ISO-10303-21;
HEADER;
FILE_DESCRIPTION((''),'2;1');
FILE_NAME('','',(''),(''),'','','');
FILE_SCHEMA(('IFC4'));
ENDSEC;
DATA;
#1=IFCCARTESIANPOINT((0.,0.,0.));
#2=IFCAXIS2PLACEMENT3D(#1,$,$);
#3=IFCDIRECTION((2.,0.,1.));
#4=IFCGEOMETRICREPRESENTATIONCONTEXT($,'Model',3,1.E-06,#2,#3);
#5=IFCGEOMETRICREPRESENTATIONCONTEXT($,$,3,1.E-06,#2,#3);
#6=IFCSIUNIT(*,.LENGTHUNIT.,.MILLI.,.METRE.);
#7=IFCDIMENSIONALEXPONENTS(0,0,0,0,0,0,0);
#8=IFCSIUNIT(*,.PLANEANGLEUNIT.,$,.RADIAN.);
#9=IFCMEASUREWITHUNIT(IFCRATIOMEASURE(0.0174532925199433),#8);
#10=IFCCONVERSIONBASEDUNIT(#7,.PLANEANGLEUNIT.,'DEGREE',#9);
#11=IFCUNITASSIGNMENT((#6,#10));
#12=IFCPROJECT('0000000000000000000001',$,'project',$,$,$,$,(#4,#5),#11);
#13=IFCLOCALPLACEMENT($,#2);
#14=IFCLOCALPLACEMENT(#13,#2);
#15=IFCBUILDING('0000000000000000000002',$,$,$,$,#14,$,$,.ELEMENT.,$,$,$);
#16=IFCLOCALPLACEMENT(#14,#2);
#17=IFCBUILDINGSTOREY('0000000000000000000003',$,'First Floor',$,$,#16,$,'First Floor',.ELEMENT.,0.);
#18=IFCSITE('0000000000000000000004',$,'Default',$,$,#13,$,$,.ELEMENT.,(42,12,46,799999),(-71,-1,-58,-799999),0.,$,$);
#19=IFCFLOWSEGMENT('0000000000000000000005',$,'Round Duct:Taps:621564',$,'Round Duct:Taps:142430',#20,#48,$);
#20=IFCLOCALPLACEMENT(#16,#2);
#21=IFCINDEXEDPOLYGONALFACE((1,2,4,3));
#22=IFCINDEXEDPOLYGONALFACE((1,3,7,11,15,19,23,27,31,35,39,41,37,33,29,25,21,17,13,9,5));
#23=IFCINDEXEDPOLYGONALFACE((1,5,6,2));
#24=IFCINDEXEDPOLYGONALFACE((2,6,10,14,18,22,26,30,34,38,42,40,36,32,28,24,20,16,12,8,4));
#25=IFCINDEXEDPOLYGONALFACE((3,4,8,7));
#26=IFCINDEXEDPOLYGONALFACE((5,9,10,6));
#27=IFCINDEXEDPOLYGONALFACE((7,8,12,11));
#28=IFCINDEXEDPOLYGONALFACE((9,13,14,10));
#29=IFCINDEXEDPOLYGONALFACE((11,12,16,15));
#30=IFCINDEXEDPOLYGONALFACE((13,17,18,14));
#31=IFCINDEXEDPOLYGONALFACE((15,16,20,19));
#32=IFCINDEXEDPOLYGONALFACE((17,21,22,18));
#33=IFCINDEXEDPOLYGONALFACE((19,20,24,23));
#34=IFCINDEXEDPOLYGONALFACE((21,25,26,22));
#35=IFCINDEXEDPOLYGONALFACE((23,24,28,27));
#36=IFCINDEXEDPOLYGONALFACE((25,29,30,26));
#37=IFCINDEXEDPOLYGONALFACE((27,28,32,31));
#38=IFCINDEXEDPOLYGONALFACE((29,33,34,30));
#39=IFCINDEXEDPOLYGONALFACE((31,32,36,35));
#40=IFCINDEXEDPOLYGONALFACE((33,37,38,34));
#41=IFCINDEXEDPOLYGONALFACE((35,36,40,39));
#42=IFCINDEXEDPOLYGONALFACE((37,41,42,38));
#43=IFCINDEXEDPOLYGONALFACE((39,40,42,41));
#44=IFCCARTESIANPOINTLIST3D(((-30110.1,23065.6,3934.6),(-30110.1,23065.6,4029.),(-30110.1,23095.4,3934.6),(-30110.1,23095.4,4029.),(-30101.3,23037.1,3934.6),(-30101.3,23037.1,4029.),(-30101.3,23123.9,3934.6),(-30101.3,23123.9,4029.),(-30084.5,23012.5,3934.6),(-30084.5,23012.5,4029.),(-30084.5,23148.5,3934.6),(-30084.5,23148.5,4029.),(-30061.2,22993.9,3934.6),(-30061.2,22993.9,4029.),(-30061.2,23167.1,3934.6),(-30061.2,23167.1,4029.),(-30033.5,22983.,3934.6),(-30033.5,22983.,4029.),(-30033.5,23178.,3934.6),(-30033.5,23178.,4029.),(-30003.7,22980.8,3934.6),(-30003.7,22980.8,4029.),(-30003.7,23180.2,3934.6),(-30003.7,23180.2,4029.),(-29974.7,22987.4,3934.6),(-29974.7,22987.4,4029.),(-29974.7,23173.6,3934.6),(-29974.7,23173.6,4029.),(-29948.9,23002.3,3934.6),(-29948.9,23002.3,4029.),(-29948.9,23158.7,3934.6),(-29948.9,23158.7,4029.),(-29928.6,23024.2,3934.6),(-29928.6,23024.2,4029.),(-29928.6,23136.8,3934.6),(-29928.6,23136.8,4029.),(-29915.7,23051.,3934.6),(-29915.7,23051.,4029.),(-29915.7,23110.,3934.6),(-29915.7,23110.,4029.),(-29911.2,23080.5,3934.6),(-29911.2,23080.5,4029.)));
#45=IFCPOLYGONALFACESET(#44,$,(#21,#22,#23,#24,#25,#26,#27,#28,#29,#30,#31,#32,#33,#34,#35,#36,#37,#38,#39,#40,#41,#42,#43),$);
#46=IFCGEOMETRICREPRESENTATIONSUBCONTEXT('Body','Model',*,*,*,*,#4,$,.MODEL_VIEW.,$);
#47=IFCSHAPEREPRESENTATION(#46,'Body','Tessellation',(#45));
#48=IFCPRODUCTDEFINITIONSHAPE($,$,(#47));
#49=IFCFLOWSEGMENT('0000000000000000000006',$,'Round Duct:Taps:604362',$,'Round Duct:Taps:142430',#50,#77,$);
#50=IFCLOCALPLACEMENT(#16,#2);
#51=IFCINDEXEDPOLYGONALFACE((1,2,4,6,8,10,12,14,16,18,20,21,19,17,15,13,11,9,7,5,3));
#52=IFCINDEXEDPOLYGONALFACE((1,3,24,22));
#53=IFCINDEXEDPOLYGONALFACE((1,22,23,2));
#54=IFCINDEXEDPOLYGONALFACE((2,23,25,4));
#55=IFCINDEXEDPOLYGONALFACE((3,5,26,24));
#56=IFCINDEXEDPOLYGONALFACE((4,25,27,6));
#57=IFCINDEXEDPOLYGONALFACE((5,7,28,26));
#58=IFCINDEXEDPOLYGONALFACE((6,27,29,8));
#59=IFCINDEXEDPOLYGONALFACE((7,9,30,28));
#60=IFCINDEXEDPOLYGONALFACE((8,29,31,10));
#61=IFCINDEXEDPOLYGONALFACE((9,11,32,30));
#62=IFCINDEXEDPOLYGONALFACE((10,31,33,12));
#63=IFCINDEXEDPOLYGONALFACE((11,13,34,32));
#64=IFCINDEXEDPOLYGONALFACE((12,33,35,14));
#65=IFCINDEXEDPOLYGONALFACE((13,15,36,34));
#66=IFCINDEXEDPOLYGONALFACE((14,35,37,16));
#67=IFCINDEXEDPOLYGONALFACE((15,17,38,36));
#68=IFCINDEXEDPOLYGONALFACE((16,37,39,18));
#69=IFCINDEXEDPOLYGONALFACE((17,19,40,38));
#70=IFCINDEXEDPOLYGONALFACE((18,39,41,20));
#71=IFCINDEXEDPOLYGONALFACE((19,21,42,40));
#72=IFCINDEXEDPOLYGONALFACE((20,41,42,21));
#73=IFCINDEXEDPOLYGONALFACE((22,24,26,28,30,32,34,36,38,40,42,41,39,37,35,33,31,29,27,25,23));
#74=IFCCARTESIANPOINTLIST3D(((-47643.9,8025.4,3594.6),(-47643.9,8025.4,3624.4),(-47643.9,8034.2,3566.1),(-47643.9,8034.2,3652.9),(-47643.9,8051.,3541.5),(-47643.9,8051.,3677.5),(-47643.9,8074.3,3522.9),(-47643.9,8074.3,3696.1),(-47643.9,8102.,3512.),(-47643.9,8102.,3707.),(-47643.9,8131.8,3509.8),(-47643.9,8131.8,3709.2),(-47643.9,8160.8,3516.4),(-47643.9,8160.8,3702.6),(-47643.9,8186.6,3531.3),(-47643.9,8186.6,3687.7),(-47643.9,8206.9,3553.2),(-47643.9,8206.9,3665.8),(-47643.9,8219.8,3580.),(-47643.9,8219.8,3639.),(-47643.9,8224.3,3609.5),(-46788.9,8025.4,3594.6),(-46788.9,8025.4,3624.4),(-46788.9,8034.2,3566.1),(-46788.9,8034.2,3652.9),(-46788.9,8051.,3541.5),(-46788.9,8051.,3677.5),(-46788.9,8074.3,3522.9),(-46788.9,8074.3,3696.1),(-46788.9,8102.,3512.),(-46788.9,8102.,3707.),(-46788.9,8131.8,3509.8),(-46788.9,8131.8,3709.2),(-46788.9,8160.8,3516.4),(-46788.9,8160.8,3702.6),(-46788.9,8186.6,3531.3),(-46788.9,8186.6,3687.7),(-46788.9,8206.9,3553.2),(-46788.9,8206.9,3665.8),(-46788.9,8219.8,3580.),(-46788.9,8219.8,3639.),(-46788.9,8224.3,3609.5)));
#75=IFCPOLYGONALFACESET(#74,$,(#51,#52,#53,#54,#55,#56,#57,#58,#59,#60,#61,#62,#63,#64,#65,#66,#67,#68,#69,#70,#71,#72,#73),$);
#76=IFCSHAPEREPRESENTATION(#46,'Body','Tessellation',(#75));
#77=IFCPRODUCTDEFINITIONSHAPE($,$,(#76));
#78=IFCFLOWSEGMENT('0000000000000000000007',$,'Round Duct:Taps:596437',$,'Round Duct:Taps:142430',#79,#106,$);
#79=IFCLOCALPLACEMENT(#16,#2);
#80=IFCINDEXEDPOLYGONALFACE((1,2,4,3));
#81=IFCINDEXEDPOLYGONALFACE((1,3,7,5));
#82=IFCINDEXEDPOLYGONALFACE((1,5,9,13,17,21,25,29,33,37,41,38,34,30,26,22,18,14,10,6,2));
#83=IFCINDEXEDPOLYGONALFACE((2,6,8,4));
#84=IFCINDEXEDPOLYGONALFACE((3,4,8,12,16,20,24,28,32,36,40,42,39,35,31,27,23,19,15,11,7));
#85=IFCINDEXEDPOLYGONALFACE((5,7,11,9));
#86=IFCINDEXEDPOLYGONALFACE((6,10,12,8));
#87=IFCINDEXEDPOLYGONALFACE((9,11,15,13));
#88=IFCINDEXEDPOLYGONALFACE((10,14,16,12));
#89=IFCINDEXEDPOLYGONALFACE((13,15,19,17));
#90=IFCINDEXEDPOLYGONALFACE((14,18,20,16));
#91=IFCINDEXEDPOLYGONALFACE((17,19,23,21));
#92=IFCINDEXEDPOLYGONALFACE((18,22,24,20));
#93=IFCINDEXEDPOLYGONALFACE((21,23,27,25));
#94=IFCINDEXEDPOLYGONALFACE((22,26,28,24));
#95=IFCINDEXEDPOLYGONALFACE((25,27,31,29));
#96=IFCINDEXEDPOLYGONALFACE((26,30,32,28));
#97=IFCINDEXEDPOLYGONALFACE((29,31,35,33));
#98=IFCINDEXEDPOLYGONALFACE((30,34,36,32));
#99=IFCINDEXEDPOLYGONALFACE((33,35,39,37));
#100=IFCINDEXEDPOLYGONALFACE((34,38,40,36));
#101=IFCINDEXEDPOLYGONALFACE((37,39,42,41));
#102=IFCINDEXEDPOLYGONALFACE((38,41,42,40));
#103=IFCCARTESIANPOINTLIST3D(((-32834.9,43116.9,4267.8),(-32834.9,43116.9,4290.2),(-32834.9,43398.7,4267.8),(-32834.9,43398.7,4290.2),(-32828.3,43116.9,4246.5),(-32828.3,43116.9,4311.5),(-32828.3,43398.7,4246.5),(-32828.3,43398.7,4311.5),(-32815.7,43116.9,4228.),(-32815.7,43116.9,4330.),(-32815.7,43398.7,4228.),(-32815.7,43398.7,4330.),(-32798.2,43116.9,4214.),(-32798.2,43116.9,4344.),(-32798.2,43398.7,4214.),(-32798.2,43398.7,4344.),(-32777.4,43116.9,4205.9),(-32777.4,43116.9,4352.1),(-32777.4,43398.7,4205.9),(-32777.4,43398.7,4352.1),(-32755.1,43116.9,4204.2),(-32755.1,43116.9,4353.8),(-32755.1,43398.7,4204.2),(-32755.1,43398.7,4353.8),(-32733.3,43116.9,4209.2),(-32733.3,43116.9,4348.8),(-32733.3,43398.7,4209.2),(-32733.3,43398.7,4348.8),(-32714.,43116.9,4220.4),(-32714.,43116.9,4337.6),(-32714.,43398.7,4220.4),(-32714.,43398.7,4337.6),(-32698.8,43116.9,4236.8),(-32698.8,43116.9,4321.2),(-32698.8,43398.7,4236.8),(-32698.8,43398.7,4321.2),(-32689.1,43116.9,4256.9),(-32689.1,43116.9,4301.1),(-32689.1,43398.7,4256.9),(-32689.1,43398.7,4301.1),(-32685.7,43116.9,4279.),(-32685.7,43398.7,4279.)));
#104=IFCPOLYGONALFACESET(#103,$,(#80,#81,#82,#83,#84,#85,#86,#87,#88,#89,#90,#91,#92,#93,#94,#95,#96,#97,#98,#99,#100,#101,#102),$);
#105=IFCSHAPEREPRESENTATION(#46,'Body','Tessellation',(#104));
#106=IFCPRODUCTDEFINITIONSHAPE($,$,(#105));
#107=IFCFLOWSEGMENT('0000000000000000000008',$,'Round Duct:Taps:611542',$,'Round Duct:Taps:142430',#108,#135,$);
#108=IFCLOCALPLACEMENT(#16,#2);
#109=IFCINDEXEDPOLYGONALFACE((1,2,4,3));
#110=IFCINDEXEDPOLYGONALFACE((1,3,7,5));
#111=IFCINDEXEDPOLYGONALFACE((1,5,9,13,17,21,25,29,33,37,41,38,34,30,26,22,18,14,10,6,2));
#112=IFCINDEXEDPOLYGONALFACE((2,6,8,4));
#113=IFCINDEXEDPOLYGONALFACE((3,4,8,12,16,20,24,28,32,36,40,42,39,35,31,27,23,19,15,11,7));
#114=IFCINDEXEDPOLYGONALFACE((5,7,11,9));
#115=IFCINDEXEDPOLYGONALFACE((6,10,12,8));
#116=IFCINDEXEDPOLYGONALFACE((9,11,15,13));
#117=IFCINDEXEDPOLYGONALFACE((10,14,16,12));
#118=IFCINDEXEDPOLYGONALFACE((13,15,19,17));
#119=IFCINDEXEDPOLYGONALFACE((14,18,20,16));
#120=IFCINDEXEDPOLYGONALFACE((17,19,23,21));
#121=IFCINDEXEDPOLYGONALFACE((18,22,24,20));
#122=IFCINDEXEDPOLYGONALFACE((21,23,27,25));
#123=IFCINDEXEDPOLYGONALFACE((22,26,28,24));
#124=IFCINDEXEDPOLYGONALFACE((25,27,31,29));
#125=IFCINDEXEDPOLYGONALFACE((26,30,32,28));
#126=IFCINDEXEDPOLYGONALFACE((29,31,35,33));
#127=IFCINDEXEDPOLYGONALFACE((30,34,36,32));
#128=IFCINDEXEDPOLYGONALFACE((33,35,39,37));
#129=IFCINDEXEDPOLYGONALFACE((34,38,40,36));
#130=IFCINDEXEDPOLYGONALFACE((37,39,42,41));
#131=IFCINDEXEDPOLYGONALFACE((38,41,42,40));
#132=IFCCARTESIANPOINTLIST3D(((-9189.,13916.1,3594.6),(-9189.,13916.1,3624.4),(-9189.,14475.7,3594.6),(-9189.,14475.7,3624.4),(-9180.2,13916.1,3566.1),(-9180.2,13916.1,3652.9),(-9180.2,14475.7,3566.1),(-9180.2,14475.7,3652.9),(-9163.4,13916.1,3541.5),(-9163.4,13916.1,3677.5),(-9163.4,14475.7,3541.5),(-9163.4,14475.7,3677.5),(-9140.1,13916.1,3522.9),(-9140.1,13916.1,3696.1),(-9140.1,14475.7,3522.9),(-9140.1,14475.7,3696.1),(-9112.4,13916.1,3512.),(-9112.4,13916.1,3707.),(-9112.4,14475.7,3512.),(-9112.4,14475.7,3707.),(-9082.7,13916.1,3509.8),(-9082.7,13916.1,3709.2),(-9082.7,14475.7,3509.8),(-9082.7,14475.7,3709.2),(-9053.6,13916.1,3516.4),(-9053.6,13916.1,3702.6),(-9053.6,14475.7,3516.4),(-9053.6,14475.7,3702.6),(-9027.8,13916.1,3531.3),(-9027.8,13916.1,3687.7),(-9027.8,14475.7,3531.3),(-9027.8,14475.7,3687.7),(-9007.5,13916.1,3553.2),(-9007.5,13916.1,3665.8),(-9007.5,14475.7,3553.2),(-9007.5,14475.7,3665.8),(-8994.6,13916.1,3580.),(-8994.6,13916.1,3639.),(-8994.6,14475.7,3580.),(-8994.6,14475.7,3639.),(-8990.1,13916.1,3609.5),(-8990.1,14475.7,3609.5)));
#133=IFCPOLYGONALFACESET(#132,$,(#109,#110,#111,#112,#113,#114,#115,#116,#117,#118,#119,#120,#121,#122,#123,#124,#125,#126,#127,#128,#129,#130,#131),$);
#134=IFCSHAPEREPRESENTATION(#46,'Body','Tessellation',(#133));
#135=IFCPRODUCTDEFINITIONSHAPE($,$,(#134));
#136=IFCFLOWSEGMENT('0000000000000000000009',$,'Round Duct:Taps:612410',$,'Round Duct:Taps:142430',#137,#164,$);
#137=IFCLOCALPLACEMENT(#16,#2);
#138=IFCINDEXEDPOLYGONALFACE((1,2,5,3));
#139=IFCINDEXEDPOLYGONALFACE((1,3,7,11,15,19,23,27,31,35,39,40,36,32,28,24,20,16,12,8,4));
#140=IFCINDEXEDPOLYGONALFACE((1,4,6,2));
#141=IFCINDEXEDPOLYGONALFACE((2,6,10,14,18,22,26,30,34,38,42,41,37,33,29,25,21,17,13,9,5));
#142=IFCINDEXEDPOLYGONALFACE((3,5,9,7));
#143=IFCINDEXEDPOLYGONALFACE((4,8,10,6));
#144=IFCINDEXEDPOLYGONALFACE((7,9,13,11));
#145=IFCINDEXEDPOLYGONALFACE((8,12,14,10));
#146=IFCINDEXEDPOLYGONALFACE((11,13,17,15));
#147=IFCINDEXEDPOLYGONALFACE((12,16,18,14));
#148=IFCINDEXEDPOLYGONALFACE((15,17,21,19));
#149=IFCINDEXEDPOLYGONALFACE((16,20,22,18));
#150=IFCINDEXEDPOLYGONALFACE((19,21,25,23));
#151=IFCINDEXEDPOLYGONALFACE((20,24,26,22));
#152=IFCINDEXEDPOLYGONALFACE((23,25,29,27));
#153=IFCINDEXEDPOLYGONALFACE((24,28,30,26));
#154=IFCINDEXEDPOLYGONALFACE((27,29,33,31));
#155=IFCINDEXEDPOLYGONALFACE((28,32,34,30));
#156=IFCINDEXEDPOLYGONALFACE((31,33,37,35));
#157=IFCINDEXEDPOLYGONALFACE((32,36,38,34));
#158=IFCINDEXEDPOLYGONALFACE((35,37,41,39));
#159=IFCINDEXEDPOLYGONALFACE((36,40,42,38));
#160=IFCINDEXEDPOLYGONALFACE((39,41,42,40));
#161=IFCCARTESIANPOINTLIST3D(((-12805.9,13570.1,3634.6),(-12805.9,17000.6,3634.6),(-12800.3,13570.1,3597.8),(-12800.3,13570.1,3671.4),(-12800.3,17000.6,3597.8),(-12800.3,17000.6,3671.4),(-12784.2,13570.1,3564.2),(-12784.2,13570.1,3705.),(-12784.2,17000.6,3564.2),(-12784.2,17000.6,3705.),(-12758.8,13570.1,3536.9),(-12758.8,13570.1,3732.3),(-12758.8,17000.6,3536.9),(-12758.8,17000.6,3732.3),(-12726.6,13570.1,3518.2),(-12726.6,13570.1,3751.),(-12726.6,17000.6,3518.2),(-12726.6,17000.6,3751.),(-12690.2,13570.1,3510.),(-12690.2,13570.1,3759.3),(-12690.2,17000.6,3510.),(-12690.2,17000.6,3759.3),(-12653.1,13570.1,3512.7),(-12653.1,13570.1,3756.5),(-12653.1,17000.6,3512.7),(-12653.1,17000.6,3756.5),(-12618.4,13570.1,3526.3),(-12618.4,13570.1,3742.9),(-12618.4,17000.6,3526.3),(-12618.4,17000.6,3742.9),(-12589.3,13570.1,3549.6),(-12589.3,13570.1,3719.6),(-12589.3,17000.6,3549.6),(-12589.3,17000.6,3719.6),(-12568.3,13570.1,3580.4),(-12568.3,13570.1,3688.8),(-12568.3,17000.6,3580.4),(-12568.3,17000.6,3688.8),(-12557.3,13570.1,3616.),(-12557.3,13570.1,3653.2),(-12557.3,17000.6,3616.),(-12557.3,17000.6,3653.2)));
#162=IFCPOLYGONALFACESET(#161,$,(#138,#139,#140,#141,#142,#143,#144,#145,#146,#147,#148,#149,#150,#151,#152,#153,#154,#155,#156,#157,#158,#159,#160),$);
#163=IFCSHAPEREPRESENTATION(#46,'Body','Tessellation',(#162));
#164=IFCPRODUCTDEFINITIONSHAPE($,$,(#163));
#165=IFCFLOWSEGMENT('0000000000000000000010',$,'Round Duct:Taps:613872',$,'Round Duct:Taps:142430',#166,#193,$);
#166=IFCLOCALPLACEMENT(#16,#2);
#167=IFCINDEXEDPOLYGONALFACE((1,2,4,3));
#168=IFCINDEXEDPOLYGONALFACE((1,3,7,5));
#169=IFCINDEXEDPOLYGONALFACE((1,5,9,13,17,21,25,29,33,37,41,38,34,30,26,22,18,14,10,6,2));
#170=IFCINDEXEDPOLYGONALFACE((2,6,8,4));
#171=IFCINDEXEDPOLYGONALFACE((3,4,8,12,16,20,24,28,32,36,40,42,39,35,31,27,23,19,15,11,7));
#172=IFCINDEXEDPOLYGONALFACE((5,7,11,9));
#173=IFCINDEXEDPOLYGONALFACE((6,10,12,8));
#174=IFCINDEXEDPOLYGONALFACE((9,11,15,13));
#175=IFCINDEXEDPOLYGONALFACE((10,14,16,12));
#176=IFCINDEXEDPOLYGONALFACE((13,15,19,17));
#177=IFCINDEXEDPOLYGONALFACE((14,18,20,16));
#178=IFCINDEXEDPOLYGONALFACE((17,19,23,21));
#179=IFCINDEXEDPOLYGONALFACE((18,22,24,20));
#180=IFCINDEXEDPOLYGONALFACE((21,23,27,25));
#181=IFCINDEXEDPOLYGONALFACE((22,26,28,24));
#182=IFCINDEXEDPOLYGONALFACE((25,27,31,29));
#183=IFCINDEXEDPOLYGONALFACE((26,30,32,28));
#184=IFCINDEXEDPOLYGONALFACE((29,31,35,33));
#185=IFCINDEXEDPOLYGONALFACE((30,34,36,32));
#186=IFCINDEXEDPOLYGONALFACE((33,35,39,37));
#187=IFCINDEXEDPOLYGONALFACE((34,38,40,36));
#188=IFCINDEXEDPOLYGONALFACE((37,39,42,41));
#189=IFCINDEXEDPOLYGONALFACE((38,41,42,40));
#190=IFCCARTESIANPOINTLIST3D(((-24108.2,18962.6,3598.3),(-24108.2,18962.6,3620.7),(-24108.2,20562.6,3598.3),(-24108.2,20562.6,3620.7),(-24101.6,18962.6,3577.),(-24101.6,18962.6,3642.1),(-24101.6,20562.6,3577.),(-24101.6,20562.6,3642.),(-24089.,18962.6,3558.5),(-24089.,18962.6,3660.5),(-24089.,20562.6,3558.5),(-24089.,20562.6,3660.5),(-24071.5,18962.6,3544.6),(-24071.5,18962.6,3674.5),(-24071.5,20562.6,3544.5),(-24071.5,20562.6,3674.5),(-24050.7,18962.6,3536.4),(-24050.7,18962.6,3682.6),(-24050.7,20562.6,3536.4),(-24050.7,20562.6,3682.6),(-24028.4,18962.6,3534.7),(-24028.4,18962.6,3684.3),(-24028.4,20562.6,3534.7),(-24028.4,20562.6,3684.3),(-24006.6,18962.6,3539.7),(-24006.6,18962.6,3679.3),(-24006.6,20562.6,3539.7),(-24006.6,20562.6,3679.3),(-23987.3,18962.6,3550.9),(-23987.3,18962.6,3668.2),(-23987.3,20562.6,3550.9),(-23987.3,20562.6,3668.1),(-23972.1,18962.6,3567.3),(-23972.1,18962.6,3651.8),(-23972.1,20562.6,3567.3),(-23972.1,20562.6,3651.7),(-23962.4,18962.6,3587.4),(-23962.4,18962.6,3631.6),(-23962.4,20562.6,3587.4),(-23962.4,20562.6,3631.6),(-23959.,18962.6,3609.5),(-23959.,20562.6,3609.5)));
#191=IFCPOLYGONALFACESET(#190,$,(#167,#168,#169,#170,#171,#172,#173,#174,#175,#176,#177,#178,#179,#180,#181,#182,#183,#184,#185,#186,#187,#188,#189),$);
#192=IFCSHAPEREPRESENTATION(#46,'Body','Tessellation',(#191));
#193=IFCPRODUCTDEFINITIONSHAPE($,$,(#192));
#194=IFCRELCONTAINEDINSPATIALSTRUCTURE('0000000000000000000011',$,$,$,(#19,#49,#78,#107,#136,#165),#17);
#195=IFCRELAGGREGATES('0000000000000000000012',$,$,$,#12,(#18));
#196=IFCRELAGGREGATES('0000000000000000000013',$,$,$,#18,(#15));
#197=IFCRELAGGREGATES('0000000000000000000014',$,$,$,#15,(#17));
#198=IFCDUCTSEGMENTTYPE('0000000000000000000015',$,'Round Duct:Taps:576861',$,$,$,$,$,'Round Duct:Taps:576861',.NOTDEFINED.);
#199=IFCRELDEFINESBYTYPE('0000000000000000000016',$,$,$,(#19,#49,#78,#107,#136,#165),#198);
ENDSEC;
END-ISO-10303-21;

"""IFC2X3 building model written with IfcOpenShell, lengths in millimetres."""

from ifc_helpers import new_model, entity, si_unit, converted_unit, direction, frame, frame_2d, origin, origin_2d_with_axis, place, context, subcontext, project, spatial, circle, extrude, type_object, element, save


model = new_model("IFC2X3")

# Units and contexts
model_context = context("Model", 3, precision=1e-06, world=origin(), true_north=direction((2.0, 0.0, 1.0)))
context_of_model = context(None, 3, precision=1e-06, world=origin(), true_north=direction((2.0, 0.0, 1.0)))
body_context = subcontext(model_context, "Body", "Model", "MODEL_VIEW")
ifc_project = project(units=[si_unit("LENGTHUNIT", "METRE", prefix="MILLI"), converted_unit("PLANEANGLEUNIT", "DEGREE", entity("IfcRatioMeasure", 0.0174532925199433), si_unit("PLANEANGLEUNIT", "RADIAN"), dimensions=[0, 0, 0, 0, 0, 0, 0])], contexts=[model_context, context_of_model])

# Site, building, storey
site_placement = place(None, origin())
site = spatial("IfcSite", under=ifc_project, at=site_placement, Name="Default", CompositionType="ELEMENT", RefLatitude=(42, 12, 46, 799999), RefLongitude=(-71, -1, -58, -799999), RefElevation=0.0)
building_placement = place(site_placement, origin())
building = spatial("IfcBuilding", under=site, at=building_placement, CompositionType="ELEMENT")
storey_placement = place(building_placement, origin())
storey = spatial("IfcBuildingStorey", under=building, at=storey_placement, Name="First Floor", LongName="First Floor", CompositionType="ELEMENT", Elevation=0.0)

# Flow segments
duct_segment_type_1 = type_object("IfcDuctSegmentType", Name="Round Duct:Taps:576861", ElementType="Round Duct:Taps:576861", PredefinedType="NOTDEFINED")
flow_segment_1_placement = place(storey_placement, origin())
element("IfcFlowSegment", 1, at=flow_segment_1_placement, inside=storey, type_object=duct_segment_type_1, Name="Round Duct:Taps:621564", ObjectType="Round Duct:Taps:142430", context=body_context, shape_type="SweptSolid", body=[
    extrude(circle(Radius=100.0, at=frame_2d((0.0, 0.0), x_axis=(1.0, 0.0))), frame((-30011.2, 23080.5, 3934.6)), (0.0, 0.0, 1.0), 94.4),
])
flow_segment_2_placement = place(storey_placement, origin())
element("IfcFlowSegment", 2, at=flow_segment_2_placement, inside=storey, type_object=duct_segment_type_1, Name="Round Duct:Taps:604362", ObjectType="Round Duct:Taps:142430", context=body_context, shape_type="SweptSolid", body=[
    extrude(circle(Radius=100.0, at=frame_2d((0.0, 0.0), x_axis=(1.0, 0.0))), frame((-47643.9, 8124.3, 3609.5), z_axis=(1.0, 0.0, 0.0), x_axis=(0.0, 1.0, 0.0)), (0.0, 0.0, 1.0), 855.0),
])
flow_segment_3_placement = place(storey_placement, origin())
element("IfcFlowSegment", 3, at=flow_segment_3_placement, inside=storey, type_object=duct_segment_type_1, Name="Round Duct:Taps:596437", ObjectType="Round Duct:Taps:142430", context=body_context, shape_type="SweptSolid", body=[
    extrude(circle(Radius=75.0, at=origin_2d_with_axis()), frame((-32760.7, 43116.9, 4279.0), z_axis=(0.0, 1.0, 0.0), x_axis=(1.0, 0.0, 0.0)), (0.0, 0.0, 1.0), 281.8),
])
flow_segment_4_placement = place(storey_placement, origin())
element("IfcFlowSegment", 4, at=flow_segment_4_placement, inside=storey, type_object=duct_segment_type_1, Name="Round Duct:Taps:611542", ObjectType="Round Duct:Taps:142430", context=body_context, shape_type="SweptSolid", body=[
    extrude(circle(Radius=100.0, at=frame_2d((0.0, 0.0), x_axis=(1.0, 0.0))), frame((-9090.1, 13916.1, 3609.5), z_axis=(0.0, 1.0, 0.0), x_axis=(1.0, 0.0, 0.0)), (0.0, 0.0, 1.0), 559.6),
])
flow_segment_5_placement = place(storey_placement, origin())
element("IfcFlowSegment", 5, at=flow_segment_5_placement, inside=storey, type_object=duct_segment_type_1, Name="Round Duct:Taps:612410", ObjectType="Round Duct:Taps:142430", context=body_context, shape_type="SweptSolid", body=[
    extrude(circle(Radius=125.0, at=frame_2d((0.0, 0.0), x_axis=(1.0, 0.0))), frame((-12680.9, 13570.1, 3634.6), z_axis=(0.0, 1.0, 0.0), x_axis=(-1.0, 0.0, 0.0)), (0.0, 0.0, 1.0), 3430.5),
])
flow_segment_6_placement = place(storey_placement, origin())
element("IfcFlowSegment", 6, at=flow_segment_6_placement, inside=storey, type_object=duct_segment_type_1, Name="Round Duct:Taps:613872", ObjectType="Round Duct:Taps:142430", context=body_context, shape_type="SweptSolid", body=[
    extrude(circle(Radius=75.0, at=origin_2d_with_axis()), frame((-24034.0, 18962.6, 3609.5), z_axis=(0.0, 1.0, -0.000016), x_axis=(1.0, 0.0, 0.0)), (0.0, 0.0, 1.0), 1600.0),
])

save(model, "model.ifc")
